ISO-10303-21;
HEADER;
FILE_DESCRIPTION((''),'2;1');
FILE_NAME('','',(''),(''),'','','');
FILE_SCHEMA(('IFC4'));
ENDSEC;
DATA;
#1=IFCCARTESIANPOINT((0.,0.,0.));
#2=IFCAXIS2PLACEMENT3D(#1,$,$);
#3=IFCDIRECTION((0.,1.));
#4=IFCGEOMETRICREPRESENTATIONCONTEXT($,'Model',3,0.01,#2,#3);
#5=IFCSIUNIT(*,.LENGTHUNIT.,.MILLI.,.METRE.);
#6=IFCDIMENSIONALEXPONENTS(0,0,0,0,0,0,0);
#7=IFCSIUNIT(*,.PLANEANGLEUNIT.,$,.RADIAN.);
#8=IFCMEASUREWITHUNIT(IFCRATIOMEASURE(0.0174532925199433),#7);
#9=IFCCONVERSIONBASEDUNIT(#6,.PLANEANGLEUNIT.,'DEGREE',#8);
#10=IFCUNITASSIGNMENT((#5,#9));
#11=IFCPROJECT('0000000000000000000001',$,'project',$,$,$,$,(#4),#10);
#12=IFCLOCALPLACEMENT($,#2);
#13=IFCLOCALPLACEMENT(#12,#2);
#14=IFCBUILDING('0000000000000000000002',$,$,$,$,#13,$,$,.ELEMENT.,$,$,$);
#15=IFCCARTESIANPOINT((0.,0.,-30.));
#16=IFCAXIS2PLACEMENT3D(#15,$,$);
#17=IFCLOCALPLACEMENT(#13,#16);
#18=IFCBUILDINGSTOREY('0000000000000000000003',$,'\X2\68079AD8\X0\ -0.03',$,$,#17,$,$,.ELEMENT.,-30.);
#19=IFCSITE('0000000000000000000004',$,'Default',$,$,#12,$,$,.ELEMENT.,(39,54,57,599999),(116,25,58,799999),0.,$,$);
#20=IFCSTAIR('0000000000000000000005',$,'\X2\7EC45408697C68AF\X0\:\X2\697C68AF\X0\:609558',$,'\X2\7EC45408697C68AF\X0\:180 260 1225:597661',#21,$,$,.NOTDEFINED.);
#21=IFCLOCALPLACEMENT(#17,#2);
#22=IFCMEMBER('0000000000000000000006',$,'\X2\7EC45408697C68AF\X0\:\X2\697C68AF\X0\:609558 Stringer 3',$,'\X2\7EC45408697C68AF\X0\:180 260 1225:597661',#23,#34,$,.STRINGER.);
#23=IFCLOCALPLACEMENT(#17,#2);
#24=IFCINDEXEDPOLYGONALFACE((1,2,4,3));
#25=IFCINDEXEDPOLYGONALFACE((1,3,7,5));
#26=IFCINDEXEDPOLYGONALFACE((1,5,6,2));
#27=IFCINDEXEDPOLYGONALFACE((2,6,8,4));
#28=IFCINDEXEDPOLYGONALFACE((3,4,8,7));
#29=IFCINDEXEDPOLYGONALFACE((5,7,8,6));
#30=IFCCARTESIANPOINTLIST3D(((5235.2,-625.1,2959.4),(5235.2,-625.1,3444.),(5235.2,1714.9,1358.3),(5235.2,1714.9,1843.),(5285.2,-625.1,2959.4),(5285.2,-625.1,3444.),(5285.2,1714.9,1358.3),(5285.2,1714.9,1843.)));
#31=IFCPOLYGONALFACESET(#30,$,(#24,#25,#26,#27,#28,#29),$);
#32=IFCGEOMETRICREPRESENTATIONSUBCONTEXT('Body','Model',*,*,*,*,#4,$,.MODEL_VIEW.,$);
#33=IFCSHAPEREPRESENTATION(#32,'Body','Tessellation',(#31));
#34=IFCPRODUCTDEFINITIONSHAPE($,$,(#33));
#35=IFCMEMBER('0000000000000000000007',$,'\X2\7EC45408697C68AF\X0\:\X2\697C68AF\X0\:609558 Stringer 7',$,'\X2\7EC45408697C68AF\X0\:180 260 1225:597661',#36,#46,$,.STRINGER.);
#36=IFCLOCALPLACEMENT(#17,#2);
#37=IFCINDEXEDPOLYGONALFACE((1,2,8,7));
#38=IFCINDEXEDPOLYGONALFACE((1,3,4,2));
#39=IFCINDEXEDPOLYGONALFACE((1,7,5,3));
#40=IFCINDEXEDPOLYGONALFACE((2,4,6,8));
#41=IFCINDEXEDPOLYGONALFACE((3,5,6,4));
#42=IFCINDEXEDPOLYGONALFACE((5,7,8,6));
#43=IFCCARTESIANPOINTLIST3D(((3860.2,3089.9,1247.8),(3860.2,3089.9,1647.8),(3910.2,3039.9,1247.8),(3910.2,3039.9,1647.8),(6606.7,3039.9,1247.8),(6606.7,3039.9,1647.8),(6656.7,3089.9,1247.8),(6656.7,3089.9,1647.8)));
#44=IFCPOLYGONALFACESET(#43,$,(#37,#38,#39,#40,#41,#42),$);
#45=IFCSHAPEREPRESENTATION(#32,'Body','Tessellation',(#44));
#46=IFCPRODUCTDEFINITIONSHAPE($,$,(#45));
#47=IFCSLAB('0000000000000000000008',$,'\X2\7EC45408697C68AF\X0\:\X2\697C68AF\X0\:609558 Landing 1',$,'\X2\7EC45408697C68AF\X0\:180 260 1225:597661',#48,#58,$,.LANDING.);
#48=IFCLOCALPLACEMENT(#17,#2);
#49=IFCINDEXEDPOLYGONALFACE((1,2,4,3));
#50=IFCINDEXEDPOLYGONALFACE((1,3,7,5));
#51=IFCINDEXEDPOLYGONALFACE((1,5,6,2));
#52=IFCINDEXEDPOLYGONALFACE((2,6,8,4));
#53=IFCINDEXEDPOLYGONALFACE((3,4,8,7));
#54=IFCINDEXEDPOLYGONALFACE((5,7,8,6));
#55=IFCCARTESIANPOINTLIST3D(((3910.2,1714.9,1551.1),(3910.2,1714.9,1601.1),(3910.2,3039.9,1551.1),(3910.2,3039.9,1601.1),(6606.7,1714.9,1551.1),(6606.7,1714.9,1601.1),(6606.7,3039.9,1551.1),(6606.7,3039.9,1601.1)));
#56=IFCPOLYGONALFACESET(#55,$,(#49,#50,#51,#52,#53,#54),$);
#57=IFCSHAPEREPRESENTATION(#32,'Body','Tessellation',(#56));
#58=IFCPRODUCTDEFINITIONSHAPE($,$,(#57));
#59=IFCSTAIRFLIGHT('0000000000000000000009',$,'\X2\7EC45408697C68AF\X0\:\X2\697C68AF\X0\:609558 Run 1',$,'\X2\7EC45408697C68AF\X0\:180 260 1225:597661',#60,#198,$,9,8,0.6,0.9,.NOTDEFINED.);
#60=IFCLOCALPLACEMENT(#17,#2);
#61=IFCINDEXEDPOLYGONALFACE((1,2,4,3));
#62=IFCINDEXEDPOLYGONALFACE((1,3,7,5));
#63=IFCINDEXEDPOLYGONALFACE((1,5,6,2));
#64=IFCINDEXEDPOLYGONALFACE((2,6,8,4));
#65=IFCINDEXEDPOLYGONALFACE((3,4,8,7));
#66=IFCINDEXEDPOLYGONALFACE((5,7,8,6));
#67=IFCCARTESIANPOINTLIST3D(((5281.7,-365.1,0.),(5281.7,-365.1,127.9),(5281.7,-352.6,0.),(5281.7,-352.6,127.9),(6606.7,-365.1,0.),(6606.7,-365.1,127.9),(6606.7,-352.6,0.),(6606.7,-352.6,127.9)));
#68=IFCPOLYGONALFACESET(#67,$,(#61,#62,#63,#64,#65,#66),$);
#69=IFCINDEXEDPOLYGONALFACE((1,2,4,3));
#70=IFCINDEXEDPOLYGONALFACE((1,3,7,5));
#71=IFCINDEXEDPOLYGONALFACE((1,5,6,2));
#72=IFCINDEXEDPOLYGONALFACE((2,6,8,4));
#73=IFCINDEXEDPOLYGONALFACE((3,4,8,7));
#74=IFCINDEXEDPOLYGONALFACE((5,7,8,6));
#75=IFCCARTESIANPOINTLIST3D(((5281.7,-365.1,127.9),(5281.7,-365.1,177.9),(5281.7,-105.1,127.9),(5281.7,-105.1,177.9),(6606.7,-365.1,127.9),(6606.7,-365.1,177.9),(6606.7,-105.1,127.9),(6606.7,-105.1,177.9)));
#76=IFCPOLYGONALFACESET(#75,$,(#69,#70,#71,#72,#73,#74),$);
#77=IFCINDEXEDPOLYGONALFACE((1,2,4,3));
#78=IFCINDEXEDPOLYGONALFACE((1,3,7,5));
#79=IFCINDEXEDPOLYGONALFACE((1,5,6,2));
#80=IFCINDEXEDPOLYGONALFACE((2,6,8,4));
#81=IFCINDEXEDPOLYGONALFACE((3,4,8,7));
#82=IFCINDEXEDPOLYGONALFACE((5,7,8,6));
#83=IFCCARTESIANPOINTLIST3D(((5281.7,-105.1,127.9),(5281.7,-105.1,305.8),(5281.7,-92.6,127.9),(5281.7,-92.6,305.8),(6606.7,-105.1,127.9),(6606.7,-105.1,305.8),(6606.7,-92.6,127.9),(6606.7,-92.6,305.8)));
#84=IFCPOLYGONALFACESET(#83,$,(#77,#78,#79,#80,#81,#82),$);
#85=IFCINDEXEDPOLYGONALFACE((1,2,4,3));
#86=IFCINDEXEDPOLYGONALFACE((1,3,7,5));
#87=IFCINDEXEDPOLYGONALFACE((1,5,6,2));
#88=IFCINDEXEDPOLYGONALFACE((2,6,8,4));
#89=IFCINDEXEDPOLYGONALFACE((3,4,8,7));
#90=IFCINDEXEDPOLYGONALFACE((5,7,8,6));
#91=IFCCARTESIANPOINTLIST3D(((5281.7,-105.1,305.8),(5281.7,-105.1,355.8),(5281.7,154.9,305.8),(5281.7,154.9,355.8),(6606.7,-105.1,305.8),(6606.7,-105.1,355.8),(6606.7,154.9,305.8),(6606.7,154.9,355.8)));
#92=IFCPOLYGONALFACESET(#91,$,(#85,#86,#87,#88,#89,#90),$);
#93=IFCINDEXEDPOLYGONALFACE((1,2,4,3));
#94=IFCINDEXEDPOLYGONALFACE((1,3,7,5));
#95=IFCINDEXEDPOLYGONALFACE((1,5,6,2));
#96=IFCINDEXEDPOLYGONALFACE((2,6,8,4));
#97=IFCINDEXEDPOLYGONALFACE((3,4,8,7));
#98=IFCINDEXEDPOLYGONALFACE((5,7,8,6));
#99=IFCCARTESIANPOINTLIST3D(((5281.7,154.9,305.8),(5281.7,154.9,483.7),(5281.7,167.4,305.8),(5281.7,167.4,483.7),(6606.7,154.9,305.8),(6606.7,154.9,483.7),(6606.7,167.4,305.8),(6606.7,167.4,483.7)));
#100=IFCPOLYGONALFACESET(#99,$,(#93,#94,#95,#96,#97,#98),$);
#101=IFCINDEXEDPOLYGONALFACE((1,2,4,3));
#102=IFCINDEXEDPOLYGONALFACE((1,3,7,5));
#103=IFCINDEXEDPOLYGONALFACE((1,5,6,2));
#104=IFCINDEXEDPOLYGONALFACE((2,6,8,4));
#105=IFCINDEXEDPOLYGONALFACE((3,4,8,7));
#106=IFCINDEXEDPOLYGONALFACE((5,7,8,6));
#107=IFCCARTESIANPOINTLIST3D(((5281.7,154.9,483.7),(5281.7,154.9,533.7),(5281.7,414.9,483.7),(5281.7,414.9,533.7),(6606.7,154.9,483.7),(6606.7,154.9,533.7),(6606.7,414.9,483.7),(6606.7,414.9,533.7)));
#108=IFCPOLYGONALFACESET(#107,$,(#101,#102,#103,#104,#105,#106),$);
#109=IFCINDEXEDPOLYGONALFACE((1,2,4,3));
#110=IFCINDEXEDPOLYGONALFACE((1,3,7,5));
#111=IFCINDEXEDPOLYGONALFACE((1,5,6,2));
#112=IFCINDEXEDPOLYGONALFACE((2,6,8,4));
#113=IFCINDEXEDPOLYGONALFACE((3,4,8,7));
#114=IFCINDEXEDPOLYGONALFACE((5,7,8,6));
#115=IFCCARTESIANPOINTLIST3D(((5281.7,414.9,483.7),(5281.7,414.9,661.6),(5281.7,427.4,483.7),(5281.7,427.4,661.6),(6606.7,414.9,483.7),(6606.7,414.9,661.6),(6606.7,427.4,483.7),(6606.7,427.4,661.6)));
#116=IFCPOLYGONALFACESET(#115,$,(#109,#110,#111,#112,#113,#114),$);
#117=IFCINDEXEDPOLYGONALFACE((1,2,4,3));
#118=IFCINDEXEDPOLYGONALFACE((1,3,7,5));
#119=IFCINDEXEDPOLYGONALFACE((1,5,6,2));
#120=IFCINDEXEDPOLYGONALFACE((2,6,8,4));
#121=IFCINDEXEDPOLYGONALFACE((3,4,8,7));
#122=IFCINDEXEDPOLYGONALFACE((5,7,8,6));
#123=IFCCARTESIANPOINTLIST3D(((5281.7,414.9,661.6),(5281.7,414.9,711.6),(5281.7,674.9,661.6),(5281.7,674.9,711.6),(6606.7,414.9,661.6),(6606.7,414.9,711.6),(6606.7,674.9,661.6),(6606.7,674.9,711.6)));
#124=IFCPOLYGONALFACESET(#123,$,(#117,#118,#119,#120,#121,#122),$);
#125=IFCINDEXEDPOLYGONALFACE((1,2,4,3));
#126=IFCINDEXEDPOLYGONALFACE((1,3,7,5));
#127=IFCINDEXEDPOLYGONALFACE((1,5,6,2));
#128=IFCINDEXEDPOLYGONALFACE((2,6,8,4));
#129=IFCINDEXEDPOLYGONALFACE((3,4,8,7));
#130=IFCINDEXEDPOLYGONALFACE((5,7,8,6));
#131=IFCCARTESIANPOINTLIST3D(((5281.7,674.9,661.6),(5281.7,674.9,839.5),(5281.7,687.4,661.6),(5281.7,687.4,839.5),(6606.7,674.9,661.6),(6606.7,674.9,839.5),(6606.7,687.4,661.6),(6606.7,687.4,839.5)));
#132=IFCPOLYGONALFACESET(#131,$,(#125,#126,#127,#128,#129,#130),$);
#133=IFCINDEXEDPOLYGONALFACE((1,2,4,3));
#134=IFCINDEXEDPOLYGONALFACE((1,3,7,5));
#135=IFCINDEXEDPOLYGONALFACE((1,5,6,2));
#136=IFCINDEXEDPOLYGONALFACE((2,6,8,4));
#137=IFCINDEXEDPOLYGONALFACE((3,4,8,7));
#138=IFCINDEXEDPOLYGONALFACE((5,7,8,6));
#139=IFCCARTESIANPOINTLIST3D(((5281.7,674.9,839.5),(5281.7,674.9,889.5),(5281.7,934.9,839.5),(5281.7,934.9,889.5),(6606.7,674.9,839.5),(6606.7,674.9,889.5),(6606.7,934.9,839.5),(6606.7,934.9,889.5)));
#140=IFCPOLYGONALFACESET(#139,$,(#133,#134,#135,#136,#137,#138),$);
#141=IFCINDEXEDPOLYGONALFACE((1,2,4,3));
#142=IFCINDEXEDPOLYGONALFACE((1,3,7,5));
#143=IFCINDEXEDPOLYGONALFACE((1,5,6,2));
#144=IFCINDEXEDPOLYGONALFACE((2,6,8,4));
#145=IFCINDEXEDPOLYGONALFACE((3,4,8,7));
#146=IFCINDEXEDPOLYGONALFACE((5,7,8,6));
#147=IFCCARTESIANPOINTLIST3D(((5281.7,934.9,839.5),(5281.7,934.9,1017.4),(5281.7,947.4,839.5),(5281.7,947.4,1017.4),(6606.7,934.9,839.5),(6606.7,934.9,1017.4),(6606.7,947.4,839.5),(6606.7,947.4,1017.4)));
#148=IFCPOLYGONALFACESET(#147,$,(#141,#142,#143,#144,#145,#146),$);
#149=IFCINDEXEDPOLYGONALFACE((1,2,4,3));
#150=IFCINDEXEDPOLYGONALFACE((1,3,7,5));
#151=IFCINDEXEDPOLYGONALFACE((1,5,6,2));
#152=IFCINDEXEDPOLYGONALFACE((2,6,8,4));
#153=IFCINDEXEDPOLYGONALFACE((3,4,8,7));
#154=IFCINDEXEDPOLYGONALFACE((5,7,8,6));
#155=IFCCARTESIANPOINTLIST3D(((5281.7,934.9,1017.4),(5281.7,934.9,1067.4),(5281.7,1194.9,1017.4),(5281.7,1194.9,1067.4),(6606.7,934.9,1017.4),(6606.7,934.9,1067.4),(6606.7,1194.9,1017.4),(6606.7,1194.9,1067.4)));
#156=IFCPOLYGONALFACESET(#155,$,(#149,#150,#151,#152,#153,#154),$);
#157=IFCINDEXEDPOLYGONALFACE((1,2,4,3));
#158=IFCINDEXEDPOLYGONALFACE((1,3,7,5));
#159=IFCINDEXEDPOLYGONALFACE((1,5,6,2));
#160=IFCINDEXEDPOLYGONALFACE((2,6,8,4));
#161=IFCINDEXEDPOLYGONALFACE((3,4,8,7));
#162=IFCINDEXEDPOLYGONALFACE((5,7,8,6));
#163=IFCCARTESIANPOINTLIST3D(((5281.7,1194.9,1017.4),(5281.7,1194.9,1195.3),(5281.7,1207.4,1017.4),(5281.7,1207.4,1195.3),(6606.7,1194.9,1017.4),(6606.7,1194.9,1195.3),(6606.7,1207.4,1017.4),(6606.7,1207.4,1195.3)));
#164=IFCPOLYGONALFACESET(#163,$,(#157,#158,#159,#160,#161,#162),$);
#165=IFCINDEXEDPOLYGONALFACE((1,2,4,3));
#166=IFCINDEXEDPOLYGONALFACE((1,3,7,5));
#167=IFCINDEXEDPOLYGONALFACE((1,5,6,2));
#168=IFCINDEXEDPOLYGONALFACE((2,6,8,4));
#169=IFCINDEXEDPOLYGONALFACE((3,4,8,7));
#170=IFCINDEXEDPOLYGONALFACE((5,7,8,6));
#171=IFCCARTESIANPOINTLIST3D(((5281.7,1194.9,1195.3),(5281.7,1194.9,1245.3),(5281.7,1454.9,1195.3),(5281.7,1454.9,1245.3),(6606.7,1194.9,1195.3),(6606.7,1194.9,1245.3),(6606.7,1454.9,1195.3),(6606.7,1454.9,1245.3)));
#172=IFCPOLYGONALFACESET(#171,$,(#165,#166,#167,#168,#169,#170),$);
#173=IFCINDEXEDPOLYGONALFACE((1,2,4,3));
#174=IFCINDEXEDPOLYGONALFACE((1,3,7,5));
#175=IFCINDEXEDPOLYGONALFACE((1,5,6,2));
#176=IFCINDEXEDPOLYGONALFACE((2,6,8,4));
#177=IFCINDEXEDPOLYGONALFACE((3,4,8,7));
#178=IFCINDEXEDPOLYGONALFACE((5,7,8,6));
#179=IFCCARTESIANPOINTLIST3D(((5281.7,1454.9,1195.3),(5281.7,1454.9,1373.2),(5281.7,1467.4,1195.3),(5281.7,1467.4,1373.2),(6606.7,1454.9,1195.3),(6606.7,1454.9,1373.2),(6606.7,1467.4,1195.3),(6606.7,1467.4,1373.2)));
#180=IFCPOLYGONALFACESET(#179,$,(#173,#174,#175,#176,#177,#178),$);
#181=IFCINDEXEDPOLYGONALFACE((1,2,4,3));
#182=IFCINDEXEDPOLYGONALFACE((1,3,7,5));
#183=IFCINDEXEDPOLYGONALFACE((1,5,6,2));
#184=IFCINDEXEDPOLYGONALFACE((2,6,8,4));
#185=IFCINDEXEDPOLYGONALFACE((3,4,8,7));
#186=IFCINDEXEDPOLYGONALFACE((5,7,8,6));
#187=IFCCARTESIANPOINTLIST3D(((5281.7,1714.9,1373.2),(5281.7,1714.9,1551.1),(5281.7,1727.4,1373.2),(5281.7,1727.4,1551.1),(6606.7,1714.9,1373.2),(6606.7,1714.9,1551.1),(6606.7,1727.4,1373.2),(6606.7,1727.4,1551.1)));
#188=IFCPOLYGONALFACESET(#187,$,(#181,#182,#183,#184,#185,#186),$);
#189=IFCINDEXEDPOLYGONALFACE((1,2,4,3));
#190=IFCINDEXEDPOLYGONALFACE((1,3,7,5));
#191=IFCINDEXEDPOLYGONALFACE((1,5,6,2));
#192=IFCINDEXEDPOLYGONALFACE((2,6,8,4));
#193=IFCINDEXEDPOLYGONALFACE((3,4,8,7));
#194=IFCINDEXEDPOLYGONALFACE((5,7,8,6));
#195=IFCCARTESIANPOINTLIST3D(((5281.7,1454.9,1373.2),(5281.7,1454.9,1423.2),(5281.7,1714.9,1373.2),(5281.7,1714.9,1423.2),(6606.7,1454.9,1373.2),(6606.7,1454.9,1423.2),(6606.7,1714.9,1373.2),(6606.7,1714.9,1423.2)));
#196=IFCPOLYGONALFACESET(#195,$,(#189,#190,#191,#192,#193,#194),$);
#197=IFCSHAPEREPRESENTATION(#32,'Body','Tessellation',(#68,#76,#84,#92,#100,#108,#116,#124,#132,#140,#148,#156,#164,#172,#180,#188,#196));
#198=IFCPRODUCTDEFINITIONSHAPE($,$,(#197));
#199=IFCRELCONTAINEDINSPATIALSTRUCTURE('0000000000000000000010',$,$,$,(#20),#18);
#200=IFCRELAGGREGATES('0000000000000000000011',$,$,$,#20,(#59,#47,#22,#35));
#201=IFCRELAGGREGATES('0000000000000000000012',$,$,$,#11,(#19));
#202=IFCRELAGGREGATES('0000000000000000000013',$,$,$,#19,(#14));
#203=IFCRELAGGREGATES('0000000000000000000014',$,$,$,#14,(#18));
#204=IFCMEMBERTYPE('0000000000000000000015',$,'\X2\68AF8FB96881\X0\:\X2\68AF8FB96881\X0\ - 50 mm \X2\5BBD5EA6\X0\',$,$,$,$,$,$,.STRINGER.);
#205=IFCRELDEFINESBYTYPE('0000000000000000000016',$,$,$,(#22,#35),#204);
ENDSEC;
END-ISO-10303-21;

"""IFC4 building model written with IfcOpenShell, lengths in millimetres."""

from ifc_helpers import new_model, entity, si_unit, converted_unit, direction, frame, frame_2d, origin, origin_2d_with_axis, place, context, subcontext, project, spatial, polyline, rectangle, outline, extrude, type_object, element, aggregate, save


model = new_model("IFC4")

# Units and contexts
model_context = context("Model", 3, precision=0.01, world=origin(), true_north=direction((0.0, 1.0)))
body_context = subcontext(model_context, "Body", "Model", "MODEL_VIEW")
ifc_project = project(units=[si_unit("LENGTHUNIT", "METRE", prefix="MILLI"), converted_unit("PLANEANGLEUNIT", "DEGREE", entity("IfcRatioMeasure", 0.0174532925199433), si_unit("PLANEANGLEUNIT", "RADIAN"), dimensions=[0, 0, 0, 0, 0, 0, 0])], contexts=[model_context])

# Site, building, storey
site_placement = place(None, origin())
site = spatial("IfcSite", under=ifc_project, at=site_placement, Name="Default", CompositionType="ELEMENT", RefLatitude=(39, 54, 57, 599999), RefLongitude=(116, 25, 58, 799999), RefElevation=0.0)
building_placement = place(site_placement, origin())
building = spatial("IfcBuilding", under=site, at=building_placement, CompositionType="ELEMENT")
storey_placement = place(building_placement, frame((0.0, 0.0, -30.0)))
storey = spatial("IfcBuildingStorey", under=building, at=storey_placement, Name="标高 -0.03", CompositionType="ELEMENT", Elevation=-30.0)

# Stair, members, slab, stair flight
stair_placement = place(storey_placement, origin())
stair = element("IfcStair", 1, at=stair_placement, inside=storey, Name="组合楼梯:楼梯:609558", ObjectType="组合楼梯:180 260 1225:597661", PredefinedType="NOTDEFINED")
member_type = type_object("IfcMemberType", Name="梯边梁:梯边梁 - 50 mm 宽度", PredefinedType="STRINGER")
member_1_placement = place(stair_placement, frame((5235.2, -625.1, 1358.3)))
member_1 = element("IfcMember", 2, at=member_1_placement, type_object=member_type, Name="组合楼梯:楼梯:609558 Stringer 3", ObjectType="组合楼梯:180 260 1225:597661", PredefinedType="STRINGER", context=body_context, shape_type="SweptSolid", body=[
    extrude(outline(polyline([(-1280.8, -200.0), (1554.5, -200.0), (1280.8, 200.0), (-1554.5, 200.0), (-1280.8, -200.0)])), frame((0.0, 1170.0, 1042.9), z_axis=(1.0, 0.0, 0.0), x_axis=(0.0, -0.825307, 0.564684)), (0.0, 0.0, 1.0), 50.0),
])
member_2_placement = place(stair_placement, frame((3860.2, 3039.9, 1247.8)))
member_2 = element("IfcMember", 3, at=member_2_placement, type_object=member_type, Name="组合楼梯:楼梯:609558 Stringer 7", ObjectType="组合楼梯:180 260 1225:597661", PredefinedType="STRINGER", context=body_context, shape_type="SweptSolid", body=[
    extrude(outline(polyline([(-1398.3, -25.0), (1398.3, -25.0), (1348.3, 25.0), (-1348.3, 25.0), (-1398.3, -25.0)])), frame((1398.3, 25.0, 0.0), z_axis=(0.0, 0.0, 1.0), x_axis=(-1.0, 0.0, 0.0)), (0.0, 0.0, 1.0), 400.0),
])
slab_placement = place(stair_placement, frame((3910.2, 1714.9, 0.0)))
slab = element("IfcSlab", 4, at=slab_placement, Name="组合楼梯:楼梯:609558 Landing 1", ObjectType="组合楼梯:180 260 1225:597661", PredefinedType="LANDING", context=body_context, shape_type="SweptSolid", body=[
    extrude(rectangle(XDim=2696.6, YDim=1325.0, at=frame_2d((0.0, 220.8), x_axis=(1.0, 0.0))), frame((1348.3, 441.7, 1551.1)), (0.0, 0.0, 1.0), 50.0),
])
stair_flight_1_placement = place(stair_placement, frame((5281.7, -365.1, 0.0)))
stair_flight_1 = element("IfcStairFlight", 5, at=stair_flight_1_placement, Name="组合楼梯:楼梯:609558 Run 1", ObjectType="组合楼梯:180 260 1225:597661", NumberOfRisers=9, NumberOfTreads=8, PredefinedType="NOTDEFINED", RiserHeight=0.6, TreadLength=0.9, context=body_context, shape_type="SweptSolid", body=[
    extrude(rectangle(XDim=1325.0, YDim=12.5, at=origin_2d_with_axis()), frame((662.5, 6.2, 0.0), z_axis=(0.0, 0.0, 1.0), x_axis=(-1.0, 0.0, 0.0)), (0.0, 0.0, 1.0), 127.9),
    extrude(rectangle(XDim=260.0, YDim=1325.0, at=frame_2d((0.0, 0.0), x_axis=(1.0, 0.0))), frame((662.5, 130.0, 127.9), z_axis=(0.0, 0.0, 1.0), x_axis=(0.0, -1.0, 0.0)), (0.0, 0.0, 1.0), 50.0),
    extrude(rectangle(XDim=1325.0, YDim=12.5, at=origin_2d_with_axis()), frame((662.5, 266.2, 127.9), z_axis=(0.0, 0.0, 1.0), x_axis=(-1.0, 0.0, 0.0)), (0.0, 0.0, 1.0), 177.9),
    extrude(rectangle(XDim=260.0, YDim=1325.0, at=frame_2d((0.0, 0.0), x_axis=(1.0, 0.0))), frame((662.5, 390.0, 305.8), z_axis=(0.0, 0.0, 1.0), x_axis=(0.0, -1.0, 0.0)), (0.0, 0.0, 1.0), 50.0),
    extrude(rectangle(XDim=1325.0, YDim=12.5, at=frame_2d((0.0, 0.0), x_axis=(1.0, 0.0))), frame((662.5, 526.2, 305.8), z_axis=(0.0, 0.0, 1.0), x_axis=(-1.0, 0.0, 0.0)), (0.0, 0.0, 1.0), 177.9),
    extrude(rectangle(XDim=260.0, YDim=1325.0, at=frame_2d((0.0, 0.0), x_axis=(1.0, 0.0))), frame((662.5, 650.0, 483.7), z_axis=(0.0, 0.0, 1.0), x_axis=(0.0, -1.0, 0.0)), (0.0, 0.0, 1.0), 50.0),
    extrude(rectangle(XDim=1325.0, YDim=12.5, at=origin_2d_with_axis()), frame((662.5, 786.3, 483.7), z_axis=(0.0, 0.0, 1.0), x_axis=(-1.0, 0.0, 0.0)), (0.0, 0.0, 1.0), 177.9),
    extrude(rectangle(XDim=260.0, YDim=1325.0, at=frame_2d((0.0, 0.0), x_axis=(1.0, 0.0))), frame((662.5, 910.0, 661.6), z_axis=(0.0, 0.0, 1.0), x_axis=(0.0, -1.0, 0.0)), (0.0, 0.0, 1.0), 50.0),
    extrude(rectangle(XDim=1325.0, YDim=12.5, at=origin_2d_with_axis()), frame((662.5, 1046.2, 661.6), z_axis=(0.0, 0.0, 1.0), x_axis=(-1.0, 0.0, 0.0)), (0.0, 0.0, 1.0), 177.9),
    extrude(rectangle(XDim=260.0, YDim=1325.0, at=frame_2d((0.0, 0.0), x_axis=(1.0, 0.0))), frame((662.5, 1170.0, 839.5), z_axis=(0.0, 0.0, 1.0), x_axis=(0.0, -1.0, 0.0)), (0.0, 0.0, 1.0), 50.0),
    extrude(rectangle(XDim=1325.0, YDim=12.5, at=origin_2d_with_axis()), frame((662.5, 1306.2, 839.5), z_axis=(0.0, 0.0, 1.0), x_axis=(-1.0, 0.0, 0.0)), (0.0, 0.0, 1.0), 177.9),
    extrude(rectangle(XDim=260.0, YDim=1325.0, at=frame_2d((0.0, 0.0), x_axis=(1.0, 0.0))), frame((662.5, 1430.0, 1017.4), z_axis=(0.0, 0.0, 1.0), x_axis=(0.0, -1.0, 0.0)), (0.0, 0.0, 1.0), 50.0),
    extrude(rectangle(XDim=1325.0, YDim=12.5, at=origin_2d_with_axis()), frame((662.5, 1566.2, 1017.4), z_axis=(0.0, 0.0, 1.0), x_axis=(-1.0, 0.0, 0.0)), (0.0, 0.0, 1.0), 177.9),
    extrude(rectangle(XDim=260.0, YDim=1325.0, at=frame_2d((0.0, 0.0), x_axis=(1.0, 0.0))), frame((662.5, 1690.0, 1195.3), z_axis=(0.0, 0.0, 1.0), x_axis=(0.0, -1.0, 0.0)), (0.0, 0.0, 1.0), 50.0),
    extrude(rectangle(XDim=1325.0, YDim=12.5, at=frame_2d((0.0, 0.0), x_axis=(1.0, 0.0))), frame((662.5, 1826.2, 1195.3), z_axis=(0.0, 0.0, 1.0), x_axis=(-1.0, 0.0, 0.0)), (0.0, 0.0, 1.0), 177.9),
    extrude(rectangle(XDim=1325.0, YDim=12.5, at=frame_2d((0.0, 0.0), x_axis=(1.0, 0.0))), frame((662.5, 2086.2, 1373.2), z_axis=(0.0, 0.0, 1.0), x_axis=(-1.0, 0.0, 0.0)), (0.0, 0.0, 1.0), 177.9),
    extrude(rectangle(XDim=260.0, YDim=1325.0, at=frame_2d((0.0, 0.0), x_axis=(1.0, 0.0))), frame((662.5, 1950.0, 1373.2), z_axis=(0.0, 0.0, 1.0), x_axis=(0.0, -1.0, 0.0)), (0.0, 0.0, 1.0), 50.0),
])
aggregate(stair, [stair_flight_1, slab, member_1, member_2])

save(model, "model.ifc")
